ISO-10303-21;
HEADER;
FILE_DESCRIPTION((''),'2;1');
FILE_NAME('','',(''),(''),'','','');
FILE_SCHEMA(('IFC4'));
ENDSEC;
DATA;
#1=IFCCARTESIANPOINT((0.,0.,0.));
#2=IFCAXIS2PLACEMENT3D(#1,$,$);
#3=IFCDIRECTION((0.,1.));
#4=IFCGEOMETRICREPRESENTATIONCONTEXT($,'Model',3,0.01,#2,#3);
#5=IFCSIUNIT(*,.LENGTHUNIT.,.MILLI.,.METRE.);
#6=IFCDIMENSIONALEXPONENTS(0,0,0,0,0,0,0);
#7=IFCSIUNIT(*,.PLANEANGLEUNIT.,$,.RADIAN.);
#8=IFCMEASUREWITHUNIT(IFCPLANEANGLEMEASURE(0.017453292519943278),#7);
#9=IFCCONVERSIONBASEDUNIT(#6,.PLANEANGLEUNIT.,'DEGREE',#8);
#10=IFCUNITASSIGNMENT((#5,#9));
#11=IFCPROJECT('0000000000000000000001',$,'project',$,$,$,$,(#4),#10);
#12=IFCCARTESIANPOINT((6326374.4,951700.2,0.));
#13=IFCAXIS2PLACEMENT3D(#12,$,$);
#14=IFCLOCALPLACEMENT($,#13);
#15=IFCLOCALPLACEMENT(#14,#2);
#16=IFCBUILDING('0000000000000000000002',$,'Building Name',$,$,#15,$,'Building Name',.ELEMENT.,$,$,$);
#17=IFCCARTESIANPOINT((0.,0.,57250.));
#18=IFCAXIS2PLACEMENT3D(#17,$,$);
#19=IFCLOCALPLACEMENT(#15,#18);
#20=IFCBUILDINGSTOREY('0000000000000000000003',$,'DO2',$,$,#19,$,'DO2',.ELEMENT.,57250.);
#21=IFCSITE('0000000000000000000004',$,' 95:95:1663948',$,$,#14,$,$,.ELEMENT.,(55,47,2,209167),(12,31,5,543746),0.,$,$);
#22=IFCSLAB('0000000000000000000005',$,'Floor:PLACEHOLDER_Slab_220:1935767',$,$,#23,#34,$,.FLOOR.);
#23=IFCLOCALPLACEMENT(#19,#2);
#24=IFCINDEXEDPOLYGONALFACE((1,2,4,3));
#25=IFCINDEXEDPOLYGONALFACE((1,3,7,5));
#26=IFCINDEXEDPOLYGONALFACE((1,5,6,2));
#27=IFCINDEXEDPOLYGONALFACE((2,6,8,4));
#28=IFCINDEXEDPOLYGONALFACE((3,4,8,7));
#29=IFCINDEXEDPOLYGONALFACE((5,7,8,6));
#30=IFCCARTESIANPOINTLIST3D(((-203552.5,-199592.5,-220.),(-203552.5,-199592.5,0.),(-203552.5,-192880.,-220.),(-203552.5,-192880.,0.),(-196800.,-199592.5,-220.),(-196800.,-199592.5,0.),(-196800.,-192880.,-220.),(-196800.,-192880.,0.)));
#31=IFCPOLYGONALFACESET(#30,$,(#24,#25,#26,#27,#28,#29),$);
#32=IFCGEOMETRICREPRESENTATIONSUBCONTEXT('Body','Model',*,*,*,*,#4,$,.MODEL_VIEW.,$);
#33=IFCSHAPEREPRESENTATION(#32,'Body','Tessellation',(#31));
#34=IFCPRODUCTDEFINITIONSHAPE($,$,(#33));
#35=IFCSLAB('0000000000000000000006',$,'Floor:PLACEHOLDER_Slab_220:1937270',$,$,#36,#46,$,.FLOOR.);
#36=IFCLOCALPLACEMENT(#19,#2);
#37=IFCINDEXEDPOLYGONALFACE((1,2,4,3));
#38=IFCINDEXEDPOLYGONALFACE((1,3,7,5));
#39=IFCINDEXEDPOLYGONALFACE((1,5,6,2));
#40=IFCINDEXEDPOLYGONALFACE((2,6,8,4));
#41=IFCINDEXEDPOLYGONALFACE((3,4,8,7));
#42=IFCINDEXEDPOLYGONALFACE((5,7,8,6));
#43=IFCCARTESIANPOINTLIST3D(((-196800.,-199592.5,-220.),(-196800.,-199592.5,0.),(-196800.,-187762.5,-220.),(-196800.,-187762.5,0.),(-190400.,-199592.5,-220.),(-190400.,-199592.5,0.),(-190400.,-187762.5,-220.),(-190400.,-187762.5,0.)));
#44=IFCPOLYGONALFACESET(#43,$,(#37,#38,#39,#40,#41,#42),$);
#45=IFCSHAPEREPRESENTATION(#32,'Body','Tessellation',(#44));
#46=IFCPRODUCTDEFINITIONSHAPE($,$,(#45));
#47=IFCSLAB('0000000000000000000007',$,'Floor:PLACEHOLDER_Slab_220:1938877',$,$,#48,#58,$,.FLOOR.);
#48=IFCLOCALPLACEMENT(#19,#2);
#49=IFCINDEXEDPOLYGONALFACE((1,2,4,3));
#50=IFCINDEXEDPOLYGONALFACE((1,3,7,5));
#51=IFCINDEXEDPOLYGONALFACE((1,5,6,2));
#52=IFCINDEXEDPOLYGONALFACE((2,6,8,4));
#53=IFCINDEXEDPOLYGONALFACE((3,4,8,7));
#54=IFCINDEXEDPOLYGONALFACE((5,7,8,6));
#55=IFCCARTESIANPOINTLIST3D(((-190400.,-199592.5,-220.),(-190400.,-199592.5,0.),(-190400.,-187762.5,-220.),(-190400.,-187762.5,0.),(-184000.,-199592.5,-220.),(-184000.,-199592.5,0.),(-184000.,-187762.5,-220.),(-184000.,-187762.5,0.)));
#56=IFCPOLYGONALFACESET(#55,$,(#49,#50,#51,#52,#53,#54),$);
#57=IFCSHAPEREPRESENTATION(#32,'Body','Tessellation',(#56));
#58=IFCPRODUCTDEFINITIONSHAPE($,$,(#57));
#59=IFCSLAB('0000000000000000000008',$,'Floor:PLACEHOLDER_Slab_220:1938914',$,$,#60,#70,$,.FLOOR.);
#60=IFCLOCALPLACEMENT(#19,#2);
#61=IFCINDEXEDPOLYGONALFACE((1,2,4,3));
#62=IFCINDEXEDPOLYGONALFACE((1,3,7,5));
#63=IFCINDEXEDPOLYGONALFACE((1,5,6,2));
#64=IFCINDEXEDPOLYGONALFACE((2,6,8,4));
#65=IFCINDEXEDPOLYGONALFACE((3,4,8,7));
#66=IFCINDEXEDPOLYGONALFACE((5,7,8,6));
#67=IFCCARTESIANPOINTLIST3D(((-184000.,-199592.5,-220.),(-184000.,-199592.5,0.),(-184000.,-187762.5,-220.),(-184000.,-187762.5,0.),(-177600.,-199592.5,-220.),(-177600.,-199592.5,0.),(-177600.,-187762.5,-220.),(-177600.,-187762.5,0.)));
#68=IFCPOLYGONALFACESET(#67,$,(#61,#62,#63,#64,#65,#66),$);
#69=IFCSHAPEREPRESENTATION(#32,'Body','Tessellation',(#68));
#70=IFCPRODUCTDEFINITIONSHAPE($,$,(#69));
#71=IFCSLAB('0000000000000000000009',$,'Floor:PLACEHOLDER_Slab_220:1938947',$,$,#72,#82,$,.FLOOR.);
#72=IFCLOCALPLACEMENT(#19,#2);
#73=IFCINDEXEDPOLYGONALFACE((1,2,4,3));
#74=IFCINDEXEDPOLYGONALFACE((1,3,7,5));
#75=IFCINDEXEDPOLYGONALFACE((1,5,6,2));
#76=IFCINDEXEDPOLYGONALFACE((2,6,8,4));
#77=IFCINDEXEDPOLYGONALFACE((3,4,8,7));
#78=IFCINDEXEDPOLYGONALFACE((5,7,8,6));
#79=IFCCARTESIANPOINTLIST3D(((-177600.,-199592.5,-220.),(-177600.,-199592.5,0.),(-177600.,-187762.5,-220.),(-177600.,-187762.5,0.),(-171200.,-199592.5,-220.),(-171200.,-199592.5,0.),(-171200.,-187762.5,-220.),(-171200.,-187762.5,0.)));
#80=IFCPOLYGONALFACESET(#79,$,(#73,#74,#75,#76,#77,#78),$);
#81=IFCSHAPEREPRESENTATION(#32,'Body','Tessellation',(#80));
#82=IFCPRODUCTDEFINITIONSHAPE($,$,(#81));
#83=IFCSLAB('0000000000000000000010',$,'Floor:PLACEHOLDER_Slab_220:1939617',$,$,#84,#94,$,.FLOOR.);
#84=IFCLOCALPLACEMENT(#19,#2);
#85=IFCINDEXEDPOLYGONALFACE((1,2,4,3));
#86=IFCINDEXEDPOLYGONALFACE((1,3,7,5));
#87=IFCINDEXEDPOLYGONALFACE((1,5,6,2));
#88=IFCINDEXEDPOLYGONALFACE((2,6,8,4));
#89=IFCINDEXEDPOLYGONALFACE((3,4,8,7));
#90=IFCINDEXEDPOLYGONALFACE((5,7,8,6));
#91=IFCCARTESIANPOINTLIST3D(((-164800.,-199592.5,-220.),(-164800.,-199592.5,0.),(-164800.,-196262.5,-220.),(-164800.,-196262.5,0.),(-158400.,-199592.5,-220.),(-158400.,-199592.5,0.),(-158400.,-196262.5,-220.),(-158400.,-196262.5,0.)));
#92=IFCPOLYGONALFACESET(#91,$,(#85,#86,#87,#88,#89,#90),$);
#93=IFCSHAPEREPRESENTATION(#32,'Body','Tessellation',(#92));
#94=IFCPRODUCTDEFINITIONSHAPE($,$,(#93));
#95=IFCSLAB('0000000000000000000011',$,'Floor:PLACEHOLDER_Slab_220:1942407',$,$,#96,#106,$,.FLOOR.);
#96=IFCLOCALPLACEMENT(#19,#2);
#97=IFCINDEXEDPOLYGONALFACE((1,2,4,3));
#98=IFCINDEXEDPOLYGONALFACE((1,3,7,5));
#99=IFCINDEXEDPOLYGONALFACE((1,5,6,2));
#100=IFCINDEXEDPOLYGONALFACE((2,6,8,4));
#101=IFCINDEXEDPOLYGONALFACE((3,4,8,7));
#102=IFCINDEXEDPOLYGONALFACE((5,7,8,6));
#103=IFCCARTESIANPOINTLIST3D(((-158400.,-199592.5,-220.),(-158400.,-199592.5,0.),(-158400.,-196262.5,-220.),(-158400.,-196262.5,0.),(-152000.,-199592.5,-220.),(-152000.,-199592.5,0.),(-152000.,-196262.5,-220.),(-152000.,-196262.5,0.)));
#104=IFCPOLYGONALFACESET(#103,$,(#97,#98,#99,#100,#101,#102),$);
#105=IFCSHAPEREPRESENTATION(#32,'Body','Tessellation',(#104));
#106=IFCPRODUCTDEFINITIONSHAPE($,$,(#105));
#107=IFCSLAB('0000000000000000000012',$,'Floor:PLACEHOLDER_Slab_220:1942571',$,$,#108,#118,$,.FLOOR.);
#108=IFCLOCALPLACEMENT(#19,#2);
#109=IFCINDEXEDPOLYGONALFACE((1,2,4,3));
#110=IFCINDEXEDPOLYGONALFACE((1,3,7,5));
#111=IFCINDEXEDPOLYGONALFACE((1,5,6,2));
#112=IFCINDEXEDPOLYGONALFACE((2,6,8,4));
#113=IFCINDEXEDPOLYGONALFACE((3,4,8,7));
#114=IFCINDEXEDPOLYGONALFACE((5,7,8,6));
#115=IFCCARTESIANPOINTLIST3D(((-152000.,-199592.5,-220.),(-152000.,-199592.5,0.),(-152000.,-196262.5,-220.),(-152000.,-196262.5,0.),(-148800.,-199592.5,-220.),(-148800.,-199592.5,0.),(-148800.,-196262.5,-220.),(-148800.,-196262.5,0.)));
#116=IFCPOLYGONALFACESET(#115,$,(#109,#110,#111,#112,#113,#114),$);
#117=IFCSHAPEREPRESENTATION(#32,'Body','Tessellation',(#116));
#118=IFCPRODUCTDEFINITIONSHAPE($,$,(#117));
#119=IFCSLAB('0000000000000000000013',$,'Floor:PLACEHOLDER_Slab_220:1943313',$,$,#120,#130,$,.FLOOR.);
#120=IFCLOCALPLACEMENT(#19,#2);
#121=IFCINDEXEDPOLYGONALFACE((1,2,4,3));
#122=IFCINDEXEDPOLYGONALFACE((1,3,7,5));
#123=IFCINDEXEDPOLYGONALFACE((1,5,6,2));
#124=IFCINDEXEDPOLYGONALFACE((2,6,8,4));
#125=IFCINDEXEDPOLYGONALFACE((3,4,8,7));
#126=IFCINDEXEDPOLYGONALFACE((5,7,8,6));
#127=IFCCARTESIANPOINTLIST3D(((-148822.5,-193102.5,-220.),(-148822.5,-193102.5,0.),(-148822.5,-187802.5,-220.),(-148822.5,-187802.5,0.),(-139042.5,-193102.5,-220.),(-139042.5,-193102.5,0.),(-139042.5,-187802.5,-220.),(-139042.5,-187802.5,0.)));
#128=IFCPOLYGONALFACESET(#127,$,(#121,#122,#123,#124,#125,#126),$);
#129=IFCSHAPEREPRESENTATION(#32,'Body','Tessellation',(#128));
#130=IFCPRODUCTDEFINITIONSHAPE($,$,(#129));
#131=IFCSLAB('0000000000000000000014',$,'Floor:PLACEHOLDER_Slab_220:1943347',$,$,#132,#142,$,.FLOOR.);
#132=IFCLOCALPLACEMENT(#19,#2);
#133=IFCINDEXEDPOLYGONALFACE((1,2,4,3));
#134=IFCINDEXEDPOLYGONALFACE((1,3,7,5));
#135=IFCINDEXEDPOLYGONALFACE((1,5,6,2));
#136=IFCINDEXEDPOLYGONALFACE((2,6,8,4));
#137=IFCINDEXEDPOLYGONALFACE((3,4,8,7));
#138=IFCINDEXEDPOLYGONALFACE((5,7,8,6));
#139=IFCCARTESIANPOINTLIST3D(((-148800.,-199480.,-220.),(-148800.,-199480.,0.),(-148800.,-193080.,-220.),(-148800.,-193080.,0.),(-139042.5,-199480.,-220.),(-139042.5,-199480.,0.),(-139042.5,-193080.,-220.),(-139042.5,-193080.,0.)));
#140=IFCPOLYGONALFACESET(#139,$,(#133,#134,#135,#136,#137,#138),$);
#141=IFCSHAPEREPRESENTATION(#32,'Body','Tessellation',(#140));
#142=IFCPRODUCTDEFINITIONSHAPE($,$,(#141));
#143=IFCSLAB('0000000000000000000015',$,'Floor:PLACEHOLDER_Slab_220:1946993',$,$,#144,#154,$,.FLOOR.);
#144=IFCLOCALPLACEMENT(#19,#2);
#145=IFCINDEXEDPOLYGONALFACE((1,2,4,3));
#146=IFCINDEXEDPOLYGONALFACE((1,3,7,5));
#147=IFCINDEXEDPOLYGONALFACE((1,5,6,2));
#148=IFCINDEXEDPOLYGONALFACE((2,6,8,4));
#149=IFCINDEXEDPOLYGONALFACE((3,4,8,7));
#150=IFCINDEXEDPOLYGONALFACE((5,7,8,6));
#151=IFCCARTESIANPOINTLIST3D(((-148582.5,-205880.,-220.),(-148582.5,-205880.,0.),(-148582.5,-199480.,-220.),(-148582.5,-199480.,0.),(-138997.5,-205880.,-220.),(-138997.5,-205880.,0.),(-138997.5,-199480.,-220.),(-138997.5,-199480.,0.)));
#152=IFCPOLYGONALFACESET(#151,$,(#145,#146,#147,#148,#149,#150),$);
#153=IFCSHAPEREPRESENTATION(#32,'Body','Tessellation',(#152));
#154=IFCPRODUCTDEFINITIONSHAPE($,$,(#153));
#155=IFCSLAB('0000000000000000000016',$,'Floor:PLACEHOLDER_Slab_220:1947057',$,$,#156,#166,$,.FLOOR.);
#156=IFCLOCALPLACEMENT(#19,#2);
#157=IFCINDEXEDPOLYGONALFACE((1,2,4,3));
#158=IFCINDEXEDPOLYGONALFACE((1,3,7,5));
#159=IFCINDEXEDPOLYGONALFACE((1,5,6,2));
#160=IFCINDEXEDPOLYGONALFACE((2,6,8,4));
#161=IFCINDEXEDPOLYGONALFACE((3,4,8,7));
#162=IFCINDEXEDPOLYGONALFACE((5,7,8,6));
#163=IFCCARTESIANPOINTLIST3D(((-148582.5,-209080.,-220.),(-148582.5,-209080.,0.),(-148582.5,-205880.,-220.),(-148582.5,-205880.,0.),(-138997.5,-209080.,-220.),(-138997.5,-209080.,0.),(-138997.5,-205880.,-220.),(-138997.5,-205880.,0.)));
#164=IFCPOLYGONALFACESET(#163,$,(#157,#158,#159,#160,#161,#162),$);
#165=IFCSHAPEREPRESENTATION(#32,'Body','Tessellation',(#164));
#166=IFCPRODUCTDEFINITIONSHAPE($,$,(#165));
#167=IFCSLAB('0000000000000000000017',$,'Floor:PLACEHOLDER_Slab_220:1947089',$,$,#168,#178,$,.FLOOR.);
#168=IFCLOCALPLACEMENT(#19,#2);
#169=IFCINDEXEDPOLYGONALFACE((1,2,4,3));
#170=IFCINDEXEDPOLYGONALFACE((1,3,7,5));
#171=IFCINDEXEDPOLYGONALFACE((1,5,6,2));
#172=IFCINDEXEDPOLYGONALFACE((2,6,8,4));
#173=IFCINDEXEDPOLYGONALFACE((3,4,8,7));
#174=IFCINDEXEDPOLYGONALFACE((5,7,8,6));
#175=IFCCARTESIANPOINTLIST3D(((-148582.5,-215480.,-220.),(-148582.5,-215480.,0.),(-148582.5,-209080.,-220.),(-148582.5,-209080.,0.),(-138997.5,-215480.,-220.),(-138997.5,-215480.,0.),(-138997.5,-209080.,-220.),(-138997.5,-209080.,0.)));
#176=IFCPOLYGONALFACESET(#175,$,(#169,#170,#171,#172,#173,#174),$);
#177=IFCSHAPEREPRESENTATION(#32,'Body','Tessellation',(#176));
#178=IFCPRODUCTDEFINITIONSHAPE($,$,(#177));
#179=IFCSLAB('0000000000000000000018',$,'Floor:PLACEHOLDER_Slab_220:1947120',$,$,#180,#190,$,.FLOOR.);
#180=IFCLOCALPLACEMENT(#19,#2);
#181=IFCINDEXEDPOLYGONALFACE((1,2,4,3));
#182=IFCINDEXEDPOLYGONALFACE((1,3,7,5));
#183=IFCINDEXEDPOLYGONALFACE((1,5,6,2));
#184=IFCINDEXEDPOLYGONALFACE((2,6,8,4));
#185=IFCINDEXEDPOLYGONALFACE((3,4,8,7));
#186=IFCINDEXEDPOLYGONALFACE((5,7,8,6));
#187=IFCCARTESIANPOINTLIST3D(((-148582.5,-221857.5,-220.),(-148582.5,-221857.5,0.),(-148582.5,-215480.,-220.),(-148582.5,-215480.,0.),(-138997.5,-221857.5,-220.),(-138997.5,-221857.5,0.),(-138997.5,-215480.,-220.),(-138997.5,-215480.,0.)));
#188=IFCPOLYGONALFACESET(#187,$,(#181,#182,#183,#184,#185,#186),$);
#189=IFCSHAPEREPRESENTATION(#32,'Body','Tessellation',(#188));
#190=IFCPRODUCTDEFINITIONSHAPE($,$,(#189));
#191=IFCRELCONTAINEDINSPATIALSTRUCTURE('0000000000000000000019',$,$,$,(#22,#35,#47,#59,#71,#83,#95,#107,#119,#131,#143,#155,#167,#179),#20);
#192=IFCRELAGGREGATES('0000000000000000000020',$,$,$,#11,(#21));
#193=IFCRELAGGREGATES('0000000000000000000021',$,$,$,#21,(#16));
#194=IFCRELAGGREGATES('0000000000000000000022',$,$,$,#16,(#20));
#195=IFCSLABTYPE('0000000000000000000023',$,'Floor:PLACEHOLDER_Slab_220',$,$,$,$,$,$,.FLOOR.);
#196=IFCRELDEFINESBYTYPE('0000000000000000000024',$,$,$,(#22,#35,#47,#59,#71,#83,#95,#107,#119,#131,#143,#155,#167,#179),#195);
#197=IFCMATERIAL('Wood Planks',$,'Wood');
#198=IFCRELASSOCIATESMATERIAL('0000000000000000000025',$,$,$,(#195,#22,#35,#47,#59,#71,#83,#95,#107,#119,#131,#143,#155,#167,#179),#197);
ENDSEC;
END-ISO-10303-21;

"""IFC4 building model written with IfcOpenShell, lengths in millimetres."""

from ifc_helpers import new_model, entity, si_unit, converted_unit, direction, frame, origin, place, context, subcontext, project, spatial, indexed_curve, outline, extrude, material, type_object, element, save


model = new_model("IFC4")

# Units and contexts
model_context = context("Model", 3, precision=0.01, world=origin(), true_north=direction((0.0, 1.0)))
body_context = subcontext(model_context, "Body", "Model", "MODEL_VIEW")
ifc_project = project(units=[si_unit("LENGTHUNIT", "METRE", prefix="MILLI"), converted_unit("PLANEANGLEUNIT", "DEGREE", entity("IfcPlaneAngleMeasure", 0.017453292519943278), si_unit("PLANEANGLEUNIT", "RADIAN"), dimensions=[0, 0, 0, 0, 0, 0, 0])], contexts=[model_context])

# Site, building, storey
site_placement = place(None, frame((6326374.4, 951700.2, 0.0)))
site = spatial("IfcSite", under=ifc_project, at=site_placement, Name=" 95:95:1663948", CompositionType="ELEMENT", RefLatitude=(55, 47, 2, 209167), RefLongitude=(12, 31, 5, 543746), RefElevation=0.0)
building_placement = place(site_placement, origin())
building = spatial("IfcBuilding", under=site, at=building_placement, Name="Building Name", LongName="Building Name", CompositionType="ELEMENT")
storey_placement = place(building_placement, frame((0.0, 0.0, 57250.0)))
storey = spatial("IfcBuildingStorey", under=building, at=storey_placement, Name="DO2", LongName="DO2", CompositionType="ELEMENT", Elevation=57250.0)

# Slabs
ifc_material_1 = material(Name="Wood Planks", Category="Wood")
slab_type_1 = type_object("IfcSlabType", Name="Floor:PLACEHOLDER_Slab_220", PredefinedType="FLOOR", material=ifc_material_1)
slab_1_placement = place(storey_placement, origin())
element("IfcSlab", 1, at=slab_1_placement, inside=storey, type_object=slab_type_1, material=ifc_material_1, Name="Floor:PLACEHOLDER_Slab_220:1935767", PredefinedType="FLOOR", context=body_context, shape_type="SweptSolid", body=[
    extrude(outline(indexed_curve([(-3356.2, -3376.2), (3356.2, -3376.2), (3356.2, 3376.2), (-3356.2, 3376.2), (-3356.2, -3376.2)], self_intersect=False)), frame((-200176.2, -196236.3, 0.0), z_axis=(0.0, 0.0, -1.0), x_axis=(0.0, 1.0, 0.0)), (0.0, 0.0, 1.0), 220.0),
])
slab_2_placement = place(storey_placement, origin())
element("IfcSlab", 2, at=slab_2_placement, inside=storey, type_object=slab_type_1, material=ifc_material_1, Name="Floor:PLACEHOLDER_Slab_220:1937270", PredefinedType="FLOOR", context=body_context, shape_type="SweptSolid", body=[
    extrude(outline(indexed_curve([(-5915.0, -3200.0), (5915.0, -3200.0), (5915.0, 3200.0), (-5915.0, 3200.0), (-5915.0, -3200.0)], self_intersect=False)), frame((-193600.0, -193677.5, 0.0), z_axis=(0.0, 0.0, -1.0), x_axis=(0.0, 1.0, 0.0)), (0.0, 0.0, 1.0), 220.0),
])
slab_3_placement = place(storey_placement, origin())
element("IfcSlab", 3, at=slab_3_placement, inside=storey, type_object=slab_type_1, material=ifc_material_1, Name="Floor:PLACEHOLDER_Slab_220:1938877", PredefinedType="FLOOR", context=body_context, shape_type="SweptSolid", body=[
    extrude(outline(indexed_curve([(-5915.0, -3200.0), (5915.0, -3200.0), (5915.0, 3200.0), (-5915.0, 3200.0), (-5915.0, -3200.0)], self_intersect=False)), frame((-187200.0, -193677.5, 0.0), z_axis=(0.0, 0.0, -1.0), x_axis=(0.0, 1.0, 0.0)), (0.0, 0.0, 1.0), 220.0),
])
slab_4_placement = place(storey_placement, origin())
element("IfcSlab", 4, at=slab_4_placement, inside=storey, type_object=slab_type_1, material=ifc_material_1, Name="Floor:PLACEHOLDER_Slab_220:1938914", PredefinedType="FLOOR", context=body_context, shape_type="SweptSolid", body=[
    extrude(outline(indexed_curve([(-5915.0, -3200.0), (5915.0, -3200.0), (5915.0, 3200.0), (-5915.0, 3200.0), (-5915.0, -3200.0)], self_intersect=False)), frame((-180800.0, -193677.5, 0.0), z_axis=(0.0, 0.0, -1.0), x_axis=(0.0, 1.0, 0.0)), (0.0, 0.0, 1.0), 220.0),
])
slab_5_placement = place(storey_placement, origin())
element("IfcSlab", 5, at=slab_5_placement, inside=storey, type_object=slab_type_1, material=ifc_material_1, Name="Floor:PLACEHOLDER_Slab_220:1938947", PredefinedType="FLOOR", context=body_context, shape_type="SweptSolid", body=[
    extrude(outline(indexed_curve([(-5915.0, -3200.0), (5915.0, -3200.0), (5915.0, 3200.0), (-5915.0, 3200.0), (-5915.0, -3200.0)], self_intersect=False)), frame((-174400.0, -193677.5, 0.0), z_axis=(0.0, 0.0, -1.0), x_axis=(0.0, 1.0, 0.0)), (0.0, 0.0, 1.0), 220.0),
])
slab_6_placement = place(storey_placement, origin())
element("IfcSlab", 6, at=slab_6_placement, inside=storey, type_object=slab_type_1, material=ifc_material_1, Name="Floor:PLACEHOLDER_Slab_220:1939617", PredefinedType="FLOOR", context=body_context, shape_type="SweptSolid", body=[
    extrude(outline(indexed_curve([(-1665.0, -3200.0), (1665.0, -3200.0), (1665.0, 3200.0), (-1665.0, 3200.0), (-1665.0, -3200.0)], self_intersect=False)), frame((-161600.0, -197927.5, 0.0), z_axis=(0.0, 0.0, -1.0), x_axis=(0.0, 1.0, 0.0)), (0.0, 0.0, 1.0), 220.0),
])
slab_7_placement = place(storey_placement, origin())
element("IfcSlab", 7, at=slab_7_placement, inside=storey, type_object=slab_type_1, material=ifc_material_1, Name="Floor:PLACEHOLDER_Slab_220:1942407", PredefinedType="FLOOR", context=body_context, shape_type="SweptSolid", body=[
    extrude(outline(indexed_curve([(-1665.0, -3200.0), (1665.0, -3200.0), (1665.0, 3200.0), (-1665.0, 3200.0), (-1665.0, -3200.0)], self_intersect=False)), frame((-155200.0, -197927.5, 0.0), z_axis=(0.0, 0.0, -1.0), x_axis=(0.0, 1.0, 0.0)), (0.0, 0.0, 1.0), 220.0),
])
slab_8_placement = place(storey_placement, origin())
element("IfcSlab", 8, at=slab_8_placement, inside=storey, type_object=slab_type_1, material=ifc_material_1, Name="Floor:PLACEHOLDER_Slab_220:1942571", PredefinedType="FLOOR", context=body_context, shape_type="SweptSolid", body=[
    extrude(outline(indexed_curve([(-1665.0, -1600.0), (1665.0, -1600.0), (1665.0, 1600.0), (-1665.0, 1600.0), (-1665.0, -1600.0)], self_intersect=False)), frame((-150400.0, -197927.5, 0.0), z_axis=(0.0, 0.0, -1.0), x_axis=(0.0, 1.0, 0.0)), (0.0, 0.0, 1.0), 220.0),
])
slab_9_placement = place(storey_placement, origin())
element("IfcSlab", 9, at=slab_9_placement, inside=storey, type_object=slab_type_1, material=ifc_material_1, Name="Floor:PLACEHOLDER_Slab_220:1943313", PredefinedType="FLOOR", context=body_context, shape_type="SweptSolid", body=[
    extrude(outline(indexed_curve([(-2650.0, -4890.0), (2650.0, -4890.0), (2650.0, 4890.0), (-2650.0, 4890.0), (-2650.0, -4890.0)], self_intersect=False)), frame((-143932.5, -190452.5, 0.0), z_axis=(0.0, 0.0, -1.0), x_axis=(0.0, 1.0, 0.0)), (0.0, 0.0, 1.0), 220.0),
])
slab_10_placement = place(storey_placement, origin())
element("IfcSlab", 10, at=slab_10_placement, inside=storey, type_object=slab_type_1, material=ifc_material_1, Name="Floor:PLACEHOLDER_Slab_220:1943347", PredefinedType="FLOOR", context=body_context, shape_type="SweptSolid", body=[
    extrude(outline(indexed_curve([(-3200.0, -4878.7), (3200.0, -4878.7), (3200.0, 4878.7), (-3200.0, 4878.7), (-3200.0, -4878.7)], self_intersect=False)), frame((-143921.2, -196280.0, 0.0), z_axis=(0.0, 0.0, -1.0), x_axis=(0.0, 1.0, 0.0)), (0.0, 0.0, 1.0), 220.0),
])
slab_11_placement = place(storey_placement, origin())
element("IfcSlab", 11, at=slab_11_placement, inside=storey, type_object=slab_type_1, material=ifc_material_1, Name="Floor:PLACEHOLDER_Slab_220:1946993", PredefinedType="FLOOR", context=body_context, shape_type="SweptSolid", body=[
    extrude(outline(indexed_curve([(-3200.0, -4792.5), (3200.0, -4792.5), (3200.0, 4792.5), (-3200.0, 4792.5), (-3200.0, -4792.5)], self_intersect=False)), frame((-143790.0, -202680.0, 0.0), z_axis=(0.0, 0.0, -1.0), x_axis=(0.0, 1.0, 0.0)), (0.0, 0.0, 1.0), 220.0),
])
slab_12_placement = place(storey_placement, origin())
element("IfcSlab", 12, at=slab_12_placement, inside=storey, type_object=slab_type_1, material=ifc_material_1, Name="Floor:PLACEHOLDER_Slab_220:1947057", PredefinedType="FLOOR", context=body_context, shape_type="SweptSolid", body=[
    extrude(outline(indexed_curve([(-1600.0, -4792.5), (1600.0, -4792.5), (1600.0, 4792.5), (-1600.0, 4792.5), (-1600.0, -4792.5)], self_intersect=False)), frame((-143790.0, -207480.0, 0.0), z_axis=(0.0, 0.0, -1.0), x_axis=(0.0, 1.0, 0.0)), (0.0, 0.0, 1.0), 220.0),
])
slab_13_placement = place(storey_placement, origin())
element("IfcSlab", 13, at=slab_13_placement, inside=storey, type_object=slab_type_1, material=ifc_material_1, Name="Floor:PLACEHOLDER_Slab_220:1947089", PredefinedType="FLOOR", context=body_context, shape_type="SweptSolid", body=[
    extrude(outline(indexed_curve([(-3200.0, -4792.5), (3200.0, -4792.5), (3200.0, 4792.5), (-3200.0, 4792.5), (-3200.0, -4792.5)], self_intersect=False)), frame((-143790.0, -212280.0, 0.0), z_axis=(0.0, 0.0, -1.0), x_axis=(0.0, 1.0, 0.0)), (0.0, 0.0, 1.0), 220.0),
])
slab_14_placement = place(storey_placement, origin())
element("IfcSlab", 14, at=slab_14_placement, inside=storey, type_object=slab_type_1, material=ifc_material_1, Name="Floor:PLACEHOLDER_Slab_220:1947120", PredefinedType="FLOOR", context=body_context, shape_type="SweptSolid", body=[
    extrude(outline(indexed_curve([(-3188.7, -4792.5), (3188.8, -4792.5), (3188.8, 4792.5), (-3188.7, 4792.5), (-3188.7, -4792.5)], self_intersect=False)), frame((-143790.0, -218668.8, 0.0), z_axis=(0.0, 0.0, -1.0), x_axis=(0.0, 1.0, 0.0)), (0.0, 0.0, 1.0), 220.0),
])

save(model, "model.ifc")
